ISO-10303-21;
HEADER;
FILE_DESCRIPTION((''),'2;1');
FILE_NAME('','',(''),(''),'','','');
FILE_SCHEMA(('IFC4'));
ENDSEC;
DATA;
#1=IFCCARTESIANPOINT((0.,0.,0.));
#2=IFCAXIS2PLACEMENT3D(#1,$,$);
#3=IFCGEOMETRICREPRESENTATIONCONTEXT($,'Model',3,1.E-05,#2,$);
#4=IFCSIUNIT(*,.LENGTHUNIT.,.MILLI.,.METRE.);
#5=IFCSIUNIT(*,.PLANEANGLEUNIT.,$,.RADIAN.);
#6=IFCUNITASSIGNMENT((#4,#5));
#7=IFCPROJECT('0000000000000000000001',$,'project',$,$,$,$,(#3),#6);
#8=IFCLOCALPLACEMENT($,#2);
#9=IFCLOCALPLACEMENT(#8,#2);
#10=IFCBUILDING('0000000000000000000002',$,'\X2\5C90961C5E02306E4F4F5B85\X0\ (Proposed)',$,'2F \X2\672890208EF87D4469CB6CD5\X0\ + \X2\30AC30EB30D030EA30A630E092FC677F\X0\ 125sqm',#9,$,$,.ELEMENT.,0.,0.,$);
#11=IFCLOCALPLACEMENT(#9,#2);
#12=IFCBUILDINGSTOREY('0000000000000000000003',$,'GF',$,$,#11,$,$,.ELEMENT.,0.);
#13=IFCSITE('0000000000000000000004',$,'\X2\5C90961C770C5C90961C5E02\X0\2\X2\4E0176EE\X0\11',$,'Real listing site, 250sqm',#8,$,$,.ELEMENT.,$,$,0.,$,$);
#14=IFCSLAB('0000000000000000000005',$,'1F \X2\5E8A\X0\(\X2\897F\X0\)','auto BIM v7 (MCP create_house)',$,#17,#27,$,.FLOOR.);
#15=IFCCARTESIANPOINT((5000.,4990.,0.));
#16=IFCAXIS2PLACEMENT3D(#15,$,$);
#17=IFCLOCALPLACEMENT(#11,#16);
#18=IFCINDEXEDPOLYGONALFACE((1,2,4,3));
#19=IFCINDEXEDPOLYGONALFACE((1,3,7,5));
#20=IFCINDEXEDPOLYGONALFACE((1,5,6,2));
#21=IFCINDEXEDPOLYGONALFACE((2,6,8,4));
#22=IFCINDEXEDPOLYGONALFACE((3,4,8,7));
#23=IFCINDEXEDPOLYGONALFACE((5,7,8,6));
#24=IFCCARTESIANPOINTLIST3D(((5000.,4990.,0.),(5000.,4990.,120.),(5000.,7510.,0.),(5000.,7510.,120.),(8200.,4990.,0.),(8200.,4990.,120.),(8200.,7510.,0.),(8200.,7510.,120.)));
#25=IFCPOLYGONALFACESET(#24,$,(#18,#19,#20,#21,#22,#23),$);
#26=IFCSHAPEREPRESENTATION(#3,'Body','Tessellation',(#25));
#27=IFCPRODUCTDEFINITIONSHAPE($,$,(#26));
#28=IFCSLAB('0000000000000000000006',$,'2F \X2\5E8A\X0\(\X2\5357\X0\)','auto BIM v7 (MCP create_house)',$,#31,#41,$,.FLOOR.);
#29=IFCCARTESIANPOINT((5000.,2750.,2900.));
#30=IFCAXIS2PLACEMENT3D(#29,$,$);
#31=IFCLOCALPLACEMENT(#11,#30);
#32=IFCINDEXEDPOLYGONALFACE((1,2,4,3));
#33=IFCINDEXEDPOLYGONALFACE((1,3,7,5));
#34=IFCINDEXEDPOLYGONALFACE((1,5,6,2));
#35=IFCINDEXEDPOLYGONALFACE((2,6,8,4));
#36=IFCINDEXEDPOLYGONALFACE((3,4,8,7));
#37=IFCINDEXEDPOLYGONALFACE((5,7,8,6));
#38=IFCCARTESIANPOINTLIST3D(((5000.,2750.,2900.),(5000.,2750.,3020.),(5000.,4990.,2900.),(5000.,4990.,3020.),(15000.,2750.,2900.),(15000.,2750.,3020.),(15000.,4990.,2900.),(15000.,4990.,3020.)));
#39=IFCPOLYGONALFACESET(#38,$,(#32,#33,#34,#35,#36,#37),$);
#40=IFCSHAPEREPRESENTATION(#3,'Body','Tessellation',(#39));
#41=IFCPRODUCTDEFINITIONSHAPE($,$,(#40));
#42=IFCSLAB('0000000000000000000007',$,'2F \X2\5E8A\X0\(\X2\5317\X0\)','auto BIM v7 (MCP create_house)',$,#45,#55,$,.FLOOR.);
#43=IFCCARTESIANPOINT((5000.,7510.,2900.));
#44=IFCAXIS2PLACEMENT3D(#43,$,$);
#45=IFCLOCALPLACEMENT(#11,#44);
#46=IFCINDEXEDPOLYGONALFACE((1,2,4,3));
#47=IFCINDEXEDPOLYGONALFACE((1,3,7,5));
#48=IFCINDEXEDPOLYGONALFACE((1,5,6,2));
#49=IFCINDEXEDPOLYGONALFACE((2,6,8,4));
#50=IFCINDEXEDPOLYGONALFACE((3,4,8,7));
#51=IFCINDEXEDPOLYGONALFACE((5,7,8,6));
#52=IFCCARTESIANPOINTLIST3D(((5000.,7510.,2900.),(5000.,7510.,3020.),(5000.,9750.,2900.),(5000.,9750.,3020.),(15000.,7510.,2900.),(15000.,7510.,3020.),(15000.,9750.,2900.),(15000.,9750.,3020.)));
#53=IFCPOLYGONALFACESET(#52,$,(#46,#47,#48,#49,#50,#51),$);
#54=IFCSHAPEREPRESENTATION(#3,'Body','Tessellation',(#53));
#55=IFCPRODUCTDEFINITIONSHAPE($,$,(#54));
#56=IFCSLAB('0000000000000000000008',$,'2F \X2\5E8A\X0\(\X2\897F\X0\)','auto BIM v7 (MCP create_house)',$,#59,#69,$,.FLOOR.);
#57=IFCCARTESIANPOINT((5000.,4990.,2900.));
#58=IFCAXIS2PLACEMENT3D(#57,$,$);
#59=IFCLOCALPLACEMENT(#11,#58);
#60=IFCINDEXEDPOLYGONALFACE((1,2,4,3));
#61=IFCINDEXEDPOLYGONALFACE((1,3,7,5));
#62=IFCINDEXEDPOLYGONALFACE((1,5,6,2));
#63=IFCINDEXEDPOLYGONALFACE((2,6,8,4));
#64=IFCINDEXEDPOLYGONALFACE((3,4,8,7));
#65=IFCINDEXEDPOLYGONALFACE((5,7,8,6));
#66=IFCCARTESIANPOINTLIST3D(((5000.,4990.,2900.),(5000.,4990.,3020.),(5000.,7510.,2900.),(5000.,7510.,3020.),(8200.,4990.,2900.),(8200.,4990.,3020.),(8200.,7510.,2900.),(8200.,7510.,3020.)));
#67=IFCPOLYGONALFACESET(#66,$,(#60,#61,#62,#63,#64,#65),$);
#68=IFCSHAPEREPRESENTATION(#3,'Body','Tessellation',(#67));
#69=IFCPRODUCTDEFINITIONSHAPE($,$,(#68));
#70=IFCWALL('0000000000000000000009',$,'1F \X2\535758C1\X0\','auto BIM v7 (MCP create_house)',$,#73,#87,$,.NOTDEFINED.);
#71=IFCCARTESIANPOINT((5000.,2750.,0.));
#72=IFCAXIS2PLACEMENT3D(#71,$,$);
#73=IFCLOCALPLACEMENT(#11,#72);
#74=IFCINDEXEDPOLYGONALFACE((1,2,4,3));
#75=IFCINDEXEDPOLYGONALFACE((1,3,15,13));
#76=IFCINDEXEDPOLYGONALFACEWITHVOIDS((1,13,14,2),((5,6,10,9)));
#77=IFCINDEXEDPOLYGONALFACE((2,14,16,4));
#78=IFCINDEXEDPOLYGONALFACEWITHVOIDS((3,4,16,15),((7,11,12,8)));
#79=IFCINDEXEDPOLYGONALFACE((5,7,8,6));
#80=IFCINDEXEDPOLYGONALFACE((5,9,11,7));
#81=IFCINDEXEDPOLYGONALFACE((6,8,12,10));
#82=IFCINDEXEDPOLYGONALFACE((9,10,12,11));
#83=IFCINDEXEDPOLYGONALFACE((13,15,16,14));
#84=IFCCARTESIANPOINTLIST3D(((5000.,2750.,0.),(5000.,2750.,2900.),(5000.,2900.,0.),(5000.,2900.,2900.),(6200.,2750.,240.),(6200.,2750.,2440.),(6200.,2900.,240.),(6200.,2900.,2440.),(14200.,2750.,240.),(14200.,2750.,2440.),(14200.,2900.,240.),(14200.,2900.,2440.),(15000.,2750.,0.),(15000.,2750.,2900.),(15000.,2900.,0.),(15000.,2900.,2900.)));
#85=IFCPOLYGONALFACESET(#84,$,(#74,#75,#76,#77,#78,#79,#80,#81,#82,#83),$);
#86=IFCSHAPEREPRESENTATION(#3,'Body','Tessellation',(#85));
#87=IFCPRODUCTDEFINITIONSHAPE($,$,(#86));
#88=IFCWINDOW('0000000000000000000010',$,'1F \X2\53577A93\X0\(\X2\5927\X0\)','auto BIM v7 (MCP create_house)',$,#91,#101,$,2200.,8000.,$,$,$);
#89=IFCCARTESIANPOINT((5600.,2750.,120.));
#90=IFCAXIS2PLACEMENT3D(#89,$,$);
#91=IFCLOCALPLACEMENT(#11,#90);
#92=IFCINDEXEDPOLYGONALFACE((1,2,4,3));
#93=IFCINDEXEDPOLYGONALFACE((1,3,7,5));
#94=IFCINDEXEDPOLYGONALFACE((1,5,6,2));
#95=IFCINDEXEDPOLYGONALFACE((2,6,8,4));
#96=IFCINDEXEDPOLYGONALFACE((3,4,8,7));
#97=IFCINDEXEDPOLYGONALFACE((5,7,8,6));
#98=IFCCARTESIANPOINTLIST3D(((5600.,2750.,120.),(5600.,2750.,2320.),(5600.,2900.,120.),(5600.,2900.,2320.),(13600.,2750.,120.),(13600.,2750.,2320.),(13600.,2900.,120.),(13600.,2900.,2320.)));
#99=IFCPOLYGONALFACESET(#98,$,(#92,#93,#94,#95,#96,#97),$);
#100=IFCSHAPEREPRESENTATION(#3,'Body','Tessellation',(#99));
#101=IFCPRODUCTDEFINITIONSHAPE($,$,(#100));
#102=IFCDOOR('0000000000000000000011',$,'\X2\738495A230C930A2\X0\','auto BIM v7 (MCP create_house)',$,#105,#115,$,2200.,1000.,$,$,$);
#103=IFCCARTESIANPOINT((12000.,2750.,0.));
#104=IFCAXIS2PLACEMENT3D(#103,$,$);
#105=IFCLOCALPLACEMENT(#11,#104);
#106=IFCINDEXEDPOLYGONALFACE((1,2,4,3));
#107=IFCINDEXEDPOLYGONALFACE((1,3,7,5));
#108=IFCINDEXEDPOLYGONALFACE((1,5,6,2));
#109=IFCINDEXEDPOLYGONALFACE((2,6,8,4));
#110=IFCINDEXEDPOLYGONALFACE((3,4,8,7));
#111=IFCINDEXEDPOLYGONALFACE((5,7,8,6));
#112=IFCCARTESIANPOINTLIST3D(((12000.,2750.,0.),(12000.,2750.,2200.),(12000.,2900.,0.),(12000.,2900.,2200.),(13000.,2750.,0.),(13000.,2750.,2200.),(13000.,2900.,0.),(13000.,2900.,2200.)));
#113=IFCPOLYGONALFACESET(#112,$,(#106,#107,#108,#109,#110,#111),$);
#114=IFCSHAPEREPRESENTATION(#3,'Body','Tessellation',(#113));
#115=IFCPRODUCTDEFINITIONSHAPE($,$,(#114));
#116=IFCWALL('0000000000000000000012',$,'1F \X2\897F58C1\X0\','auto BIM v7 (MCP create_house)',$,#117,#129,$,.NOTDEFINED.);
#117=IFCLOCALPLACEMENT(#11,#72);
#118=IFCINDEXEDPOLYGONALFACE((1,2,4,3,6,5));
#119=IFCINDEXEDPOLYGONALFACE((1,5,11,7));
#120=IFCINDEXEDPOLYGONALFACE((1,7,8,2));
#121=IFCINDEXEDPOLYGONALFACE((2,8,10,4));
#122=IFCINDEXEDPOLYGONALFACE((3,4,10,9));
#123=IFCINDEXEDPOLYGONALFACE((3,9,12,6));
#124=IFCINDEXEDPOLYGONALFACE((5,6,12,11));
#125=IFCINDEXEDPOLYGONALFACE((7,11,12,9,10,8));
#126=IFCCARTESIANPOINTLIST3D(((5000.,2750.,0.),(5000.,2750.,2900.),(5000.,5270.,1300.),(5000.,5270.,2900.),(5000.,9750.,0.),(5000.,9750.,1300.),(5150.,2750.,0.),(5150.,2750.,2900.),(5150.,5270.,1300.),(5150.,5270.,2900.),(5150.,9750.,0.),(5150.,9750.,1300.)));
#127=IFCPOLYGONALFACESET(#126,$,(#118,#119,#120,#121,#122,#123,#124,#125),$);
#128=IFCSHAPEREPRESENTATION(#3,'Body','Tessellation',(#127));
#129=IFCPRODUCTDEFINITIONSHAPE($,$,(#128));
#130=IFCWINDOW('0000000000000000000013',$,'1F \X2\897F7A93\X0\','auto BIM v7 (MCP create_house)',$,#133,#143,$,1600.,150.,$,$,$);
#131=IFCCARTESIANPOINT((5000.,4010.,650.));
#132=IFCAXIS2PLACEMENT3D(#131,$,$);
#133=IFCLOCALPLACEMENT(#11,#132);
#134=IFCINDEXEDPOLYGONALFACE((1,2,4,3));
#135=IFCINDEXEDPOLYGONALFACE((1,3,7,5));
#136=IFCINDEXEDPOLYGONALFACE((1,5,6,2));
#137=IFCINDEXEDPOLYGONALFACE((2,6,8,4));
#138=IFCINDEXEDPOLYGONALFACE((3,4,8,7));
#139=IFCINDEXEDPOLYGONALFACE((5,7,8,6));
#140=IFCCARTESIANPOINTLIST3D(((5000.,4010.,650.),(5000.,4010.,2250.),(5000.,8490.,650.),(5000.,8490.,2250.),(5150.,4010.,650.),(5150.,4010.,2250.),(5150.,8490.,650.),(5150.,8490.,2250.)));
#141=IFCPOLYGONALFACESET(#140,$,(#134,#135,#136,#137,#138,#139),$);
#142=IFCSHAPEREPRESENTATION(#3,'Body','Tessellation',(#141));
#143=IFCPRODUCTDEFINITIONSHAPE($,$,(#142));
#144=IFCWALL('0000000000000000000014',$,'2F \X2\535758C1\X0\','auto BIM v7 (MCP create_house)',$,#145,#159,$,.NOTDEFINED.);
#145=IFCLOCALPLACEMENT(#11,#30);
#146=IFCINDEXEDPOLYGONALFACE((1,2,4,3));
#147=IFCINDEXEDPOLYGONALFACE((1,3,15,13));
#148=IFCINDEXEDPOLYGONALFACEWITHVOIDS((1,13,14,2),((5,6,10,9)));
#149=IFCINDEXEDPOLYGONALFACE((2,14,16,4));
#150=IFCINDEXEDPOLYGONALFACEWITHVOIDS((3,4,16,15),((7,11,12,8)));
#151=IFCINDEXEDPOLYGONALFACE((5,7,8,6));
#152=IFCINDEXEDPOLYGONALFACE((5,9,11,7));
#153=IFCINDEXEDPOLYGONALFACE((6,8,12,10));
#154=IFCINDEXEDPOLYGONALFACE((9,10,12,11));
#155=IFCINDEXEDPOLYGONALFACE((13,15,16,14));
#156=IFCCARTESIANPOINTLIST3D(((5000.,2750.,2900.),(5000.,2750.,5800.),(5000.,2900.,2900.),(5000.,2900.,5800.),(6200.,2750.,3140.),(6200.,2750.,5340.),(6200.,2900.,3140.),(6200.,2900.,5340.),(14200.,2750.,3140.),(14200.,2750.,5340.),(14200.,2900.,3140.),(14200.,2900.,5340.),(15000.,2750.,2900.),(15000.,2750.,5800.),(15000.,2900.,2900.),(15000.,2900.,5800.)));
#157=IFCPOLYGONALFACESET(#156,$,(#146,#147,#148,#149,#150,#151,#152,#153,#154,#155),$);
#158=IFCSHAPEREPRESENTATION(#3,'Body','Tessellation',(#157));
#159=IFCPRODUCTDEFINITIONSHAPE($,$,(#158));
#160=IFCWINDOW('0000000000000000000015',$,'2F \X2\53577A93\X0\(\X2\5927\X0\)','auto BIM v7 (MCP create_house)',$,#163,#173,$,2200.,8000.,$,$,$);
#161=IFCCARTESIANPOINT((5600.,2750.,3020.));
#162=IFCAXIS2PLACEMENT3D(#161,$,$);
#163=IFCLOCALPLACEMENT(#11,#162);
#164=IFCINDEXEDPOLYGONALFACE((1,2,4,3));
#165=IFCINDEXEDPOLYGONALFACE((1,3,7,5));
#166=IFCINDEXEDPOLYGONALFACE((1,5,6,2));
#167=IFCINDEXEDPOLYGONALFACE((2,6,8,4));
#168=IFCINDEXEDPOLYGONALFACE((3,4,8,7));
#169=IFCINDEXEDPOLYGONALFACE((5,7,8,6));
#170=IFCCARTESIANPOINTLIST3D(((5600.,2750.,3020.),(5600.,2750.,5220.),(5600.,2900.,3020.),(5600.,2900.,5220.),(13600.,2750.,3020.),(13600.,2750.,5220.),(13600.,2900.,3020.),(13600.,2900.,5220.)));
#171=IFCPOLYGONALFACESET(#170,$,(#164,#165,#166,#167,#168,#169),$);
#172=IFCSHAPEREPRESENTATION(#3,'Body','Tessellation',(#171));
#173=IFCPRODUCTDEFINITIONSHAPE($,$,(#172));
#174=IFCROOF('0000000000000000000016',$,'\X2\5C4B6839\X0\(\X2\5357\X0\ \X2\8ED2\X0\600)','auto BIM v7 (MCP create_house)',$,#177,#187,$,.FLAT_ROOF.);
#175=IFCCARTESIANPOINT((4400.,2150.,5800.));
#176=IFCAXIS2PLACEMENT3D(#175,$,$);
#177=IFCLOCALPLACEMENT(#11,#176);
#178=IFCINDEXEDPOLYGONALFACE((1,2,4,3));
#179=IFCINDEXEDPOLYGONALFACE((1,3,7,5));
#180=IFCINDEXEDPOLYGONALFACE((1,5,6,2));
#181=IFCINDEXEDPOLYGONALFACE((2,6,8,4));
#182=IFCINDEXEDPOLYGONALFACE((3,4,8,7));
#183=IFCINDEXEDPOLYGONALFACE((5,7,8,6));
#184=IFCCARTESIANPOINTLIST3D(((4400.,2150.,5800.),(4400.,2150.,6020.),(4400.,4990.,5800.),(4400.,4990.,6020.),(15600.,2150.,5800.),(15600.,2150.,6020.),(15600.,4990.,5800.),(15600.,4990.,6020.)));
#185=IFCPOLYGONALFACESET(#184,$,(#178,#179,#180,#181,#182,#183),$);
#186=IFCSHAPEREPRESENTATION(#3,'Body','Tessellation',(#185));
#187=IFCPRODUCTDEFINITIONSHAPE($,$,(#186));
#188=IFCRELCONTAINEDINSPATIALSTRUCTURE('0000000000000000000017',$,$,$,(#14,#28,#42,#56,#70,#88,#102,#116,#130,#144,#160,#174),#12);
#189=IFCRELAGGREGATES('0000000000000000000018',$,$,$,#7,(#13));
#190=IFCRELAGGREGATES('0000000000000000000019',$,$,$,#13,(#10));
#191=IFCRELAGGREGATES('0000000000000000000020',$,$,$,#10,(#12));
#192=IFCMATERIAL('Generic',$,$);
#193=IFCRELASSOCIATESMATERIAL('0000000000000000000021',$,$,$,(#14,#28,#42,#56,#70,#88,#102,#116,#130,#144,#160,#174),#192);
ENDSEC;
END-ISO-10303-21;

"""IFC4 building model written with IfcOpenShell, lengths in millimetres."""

from ifc_helpers import new_model, si_unit, frame, frame_2d, origin, place, context, project, spatial, rectangle, extrude, material, element, fill, save


model = new_model("IFC4")

# Units and contexts
model_context = context("Model", 3, precision=1e-05, world=origin())
ifc_project = project(units=[si_unit("LENGTHUNIT", "METRE", prefix="MILLI"), si_unit("PLANEANGLEUNIT", "RADIAN")], contexts=[model_context])

# Site, building, storey
site_placement = place(None, origin())
site = spatial("IfcSite", under=ifc_project, at=site_placement, Name="岐阜県岐阜市2丁目11", ObjectType="Real listing site, 250sqm", CompositionType="ELEMENT", RefElevation=0.0)
building_placement = place(site_placement, origin())
building = spatial("IfcBuilding", under=site, at=building_placement, Name="岐阜市の住宅 (Proposed)", ObjectType="2F 木造軸組構法 + ガルバリウム鋼板 125sqm", CompositionType="ELEMENT", ElevationOfRefHeight=0.0, ElevationOfTerrain=0.0)
storey_placement = place(building_placement, origin())
storey = spatial("IfcBuildingStorey", under=building, at=storey_placement, Name="GF", CompositionType="ELEMENT", Elevation=0.0)

# Slabs
ifc_material = material(Name="Generic")
slab_1_placement = place(storey_placement, frame((5000.0, 4990.0, 0.0)))
element("IfcSlab", 1, at=slab_1_placement, inside=storey, material=ifc_material, Name="1F 床(西)", Description="auto BIM v7 (MCP create_house)", PredefinedType="FLOOR", context=model_context, shape_type="SweptSolid", body=[
    extrude(rectangle(XDim=3200.0, YDim=2520.0, at=frame_2d((1600.0, 1260.0))), frame((5000.0, 4990.0, 0.0)), (0.0, 0.0, 1.0), 120.0),
])
slab_2_placement = place(storey_placement, frame((5000.0, 2750.0, 2900.0)))
element("IfcSlab", 2, at=slab_2_placement, inside=storey, material=ifc_material, Name="2F 床(南)", Description="auto BIM v7 (MCP create_house)", PredefinedType="FLOOR", context=model_context, shape_type="SweptSolid", body=[
    extrude(rectangle(XDim=10000.0, YDim=2240.0, at=frame_2d((5000.0, 1120.0))), frame((5000.0, 2750.0, 2900.0)), (0.0, 0.0, 1.0), 120.0),
])
slab_3_placement = place(storey_placement, frame((5000.0, 7510.0, 2900.0)))
element("IfcSlab", 3, at=slab_3_placement, inside=storey, material=ifc_material, Name="2F 床(北)", Description="auto BIM v7 (MCP create_house)", PredefinedType="FLOOR", context=model_context, shape_type="SweptSolid", body=[
    extrude(rectangle(XDim=10000.0, YDim=2240.0, at=frame_2d((5000.0, 1120.0))), frame((5000.0, 7510.0, 2900.0)), (0.0, 0.0, 1.0), 120.0),
])
slab_4_placement = place(storey_placement, frame((5000.0, 4990.0, 2900.0)))
element("IfcSlab", 4, at=slab_4_placement, inside=storey, material=ifc_material, Name="2F 床(西)", Description="auto BIM v7 (MCP create_house)", PredefinedType="FLOOR", context=model_context, shape_type="SweptSolid", body=[
    extrude(rectangle(XDim=3200.0, YDim=2520.0, at=frame_2d((1600.0, 1260.0))), frame((5000.0, 4990.0, 2900.0)), (0.0, 0.0, 1.0), 120.0),
])

# Wall, openings, window, door
wall_1_placement = place(storey_placement, frame((5000.0, 2750.0, 0.0)))
wall_1 = element("IfcWall", 5, at=wall_1_placement, inside=storey, material=ifc_material, Name="1F 南壁", Description="auto BIM v7 (MCP create_house)", PredefinedType="NOTDEFINED", context=model_context, shape_type="SweptSolid", body=[
    extrude(rectangle(XDim=10000.0, YDim=150.0, at=frame_2d((5000.0, 75.0))), frame((5000.0, 2750.0, 0.0)), (0.0, 0.0, 1.0), 2900.0),
])
opening_1_placement = place(storey_placement, frame((5600.0, 2750.0, 120.0)))
opening_1 = element("IfcOpeningElement", 6, at=opening_1_placement, cuts=wall_1, PredefinedType="NOTDEFINED", context=model_context, shape_type="SweptSolid", body=[
    extrude(rectangle(XDim=8000.0, YDim=150.0, at=frame_2d((4000.0, 75.0))), frame((5600.0, 2750.0, 120.0)), (0.0, 0.0, 1.0), 2200.0),
])
opening_2_placement = place(storey_placement, frame((12000.0, 2750.0, 0.0)))
opening_2 = element("IfcOpeningElement", 7, at=opening_2_placement, cuts=wall_1, PredefinedType="NOTDEFINED", context=model_context, shape_type="SweptSolid", body=[
    extrude(rectangle(XDim=1000.0, YDim=150.0, at=frame_2d((500.0, 75.0))), frame((12000.0, 2750.0, 0.0)), (0.0, 0.0, 1.0), 2200.0),
])
window_1_placement = place(storey_placement, frame((5600.0, 2750.0, 120.0)))
window_1 = element("IfcWindow", 8, at=window_1_placement, inside=storey, material=ifc_material, Name="1F 南窓(大)", Description="auto BIM v7 (MCP create_house)", OverallHeight=2200.0, OverallWidth=8000.0, context=model_context, shape_type="SweptSolid", body=[
    extrude(rectangle(XDim=8000.0, YDim=150.0, at=frame_2d((4000.0, 75.0))), frame((5600.0, 2750.0, 120.0)), (0.0, 0.0, 1.0), 2200.0),
])
fill(opening_1, window_1)
door_placement = place(storey_placement, frame((12000.0, 2750.0, 0.0)))
door = element("IfcDoor", 9, at=door_placement, inside=storey, material=ifc_material, Name="玄関ドア", Description="auto BIM v7 (MCP create_house)", OverallHeight=2200.0, OverallWidth=1000.0, context=model_context, shape_type="SweptSolid", body=[
    extrude(rectangle(XDim=1000.0, YDim=150.0, at=frame_2d((500.0, 75.0))), frame((12000.0, 2750.0, 0.0)), (0.0, 0.0, 1.0), 2200.0),
])
fill(opening_2, door)

# Walls, openings, windows
wall_2_placement = place(storey_placement, frame((5000.0, 2750.0, 0.0)))
wall_2 = element("IfcWall", 10, at=wall_2_placement, inside=storey, material=ifc_material, Name="1F 西壁", Description="auto BIM v7 (MCP create_house)", PredefinedType="NOTDEFINED", context=model_context, shape_type="SweptSolid", body=[
    extrude(rectangle(XDim=150.0, YDim=7000.0, at=frame_2d((75.0, 3500.0))), frame((5000.0, 2750.0, 0.0)), (0.0, 0.0, 1.0), 2900.0),
])
opening_3_placement = place(storey_placement, frame((5000.0, 4010.0, 650.0)))
opening_3 = element("IfcOpeningElement", 11, at=opening_3_placement, cuts=wall_2, PredefinedType="NOTDEFINED", context=model_context, shape_type="SweptSolid", body=[
    extrude(rectangle(XDim=150.0, YDim=4480.0, at=frame_2d((75.0, 2240.0))), frame((5000.0, 4010.0, 650.0)), (0.0, 0.0, 1.0), 1600.0),
])
window_2_placement = place(storey_placement, frame((5000.0, 4010.0, 650.0)))
window_2 = element("IfcWindow", 12, at=window_2_placement, inside=storey, material=ifc_material, Name="1F 西窓", Description="auto BIM v7 (MCP create_house)", OverallHeight=1600.0, OverallWidth=150.0, context=model_context, shape_type="SweptSolid", body=[
    extrude(rectangle(XDim=150.0, YDim=4480.0, at=frame_2d((75.0, 2240.0))), frame((5000.0, 4010.0, 650.0)), (0.0, 0.0, 1.0), 1600.0),
])
fill(opening_3, window_2)
wall_3_placement = place(storey_placement, frame((5000.0, 2750.0, 2900.0)))
wall_3 = element("IfcWall", 13, at=wall_3_placement, inside=storey, material=ifc_material, Name="2F 南壁", Description="auto BIM v7 (MCP create_house)", PredefinedType="NOTDEFINED", context=model_context, shape_type="SweptSolid", body=[
    extrude(rectangle(XDim=10000.0, YDim=150.0, at=frame_2d((5000.0, 75.0))), frame((5000.0, 2750.0, 2900.0)), (0.0, 0.0, 1.0), 2900.0),
])
opening_4_placement = place(storey_placement, frame((5600.0, 2750.0, 3020.0)))
opening_4 = element("IfcOpeningElement", 14, at=opening_4_placement, cuts=wall_3, PredefinedType="NOTDEFINED", context=model_context, shape_type="SweptSolid", body=[
    extrude(rectangle(XDim=8000.0, YDim=150.0, at=frame_2d((4000.0, 75.0))), frame((5600.0, 2750.0, 3020.0)), (0.0, 0.0, 1.0), 2200.0),
])
window_3_placement = place(storey_placement, frame((5600.0, 2750.0, 3020.0)))
window_3 = element("IfcWindow", 15, at=window_3_placement, inside=storey, material=ifc_material, Name="2F 南窓(大)", Description="auto BIM v7 (MCP create_house)", OverallHeight=2200.0, OverallWidth=8000.0, context=model_context, shape_type="SweptSolid", body=[
    extrude(rectangle(XDim=8000.0, YDim=150.0, at=frame_2d((4000.0, 75.0))), frame((5600.0, 2750.0, 3020.0)), (0.0, 0.0, 1.0), 2200.0),
])
fill(opening_4, window_3)

# Roof
roof_1_placement = place(storey_placement, frame((4400.0, 2150.0, 5800.0)))
element("IfcRoof", 16, at=roof_1_placement, inside=storey, material=ifc_material, Name="屋根(南 軒600)", Description="auto BIM v7 (MCP create_house)", PredefinedType="FLAT_ROOF", context=model_context, shape_type="SweptSolid", body=[
    extrude(rectangle(XDim=11200.0, YDim=2840.0, at=frame_2d((5600.0, 1420.0))), frame((4400.0, 2150.0, 5800.0)), (0.0, 0.0, 1.0), 220.0),
])

save(model, "model.ifc")
